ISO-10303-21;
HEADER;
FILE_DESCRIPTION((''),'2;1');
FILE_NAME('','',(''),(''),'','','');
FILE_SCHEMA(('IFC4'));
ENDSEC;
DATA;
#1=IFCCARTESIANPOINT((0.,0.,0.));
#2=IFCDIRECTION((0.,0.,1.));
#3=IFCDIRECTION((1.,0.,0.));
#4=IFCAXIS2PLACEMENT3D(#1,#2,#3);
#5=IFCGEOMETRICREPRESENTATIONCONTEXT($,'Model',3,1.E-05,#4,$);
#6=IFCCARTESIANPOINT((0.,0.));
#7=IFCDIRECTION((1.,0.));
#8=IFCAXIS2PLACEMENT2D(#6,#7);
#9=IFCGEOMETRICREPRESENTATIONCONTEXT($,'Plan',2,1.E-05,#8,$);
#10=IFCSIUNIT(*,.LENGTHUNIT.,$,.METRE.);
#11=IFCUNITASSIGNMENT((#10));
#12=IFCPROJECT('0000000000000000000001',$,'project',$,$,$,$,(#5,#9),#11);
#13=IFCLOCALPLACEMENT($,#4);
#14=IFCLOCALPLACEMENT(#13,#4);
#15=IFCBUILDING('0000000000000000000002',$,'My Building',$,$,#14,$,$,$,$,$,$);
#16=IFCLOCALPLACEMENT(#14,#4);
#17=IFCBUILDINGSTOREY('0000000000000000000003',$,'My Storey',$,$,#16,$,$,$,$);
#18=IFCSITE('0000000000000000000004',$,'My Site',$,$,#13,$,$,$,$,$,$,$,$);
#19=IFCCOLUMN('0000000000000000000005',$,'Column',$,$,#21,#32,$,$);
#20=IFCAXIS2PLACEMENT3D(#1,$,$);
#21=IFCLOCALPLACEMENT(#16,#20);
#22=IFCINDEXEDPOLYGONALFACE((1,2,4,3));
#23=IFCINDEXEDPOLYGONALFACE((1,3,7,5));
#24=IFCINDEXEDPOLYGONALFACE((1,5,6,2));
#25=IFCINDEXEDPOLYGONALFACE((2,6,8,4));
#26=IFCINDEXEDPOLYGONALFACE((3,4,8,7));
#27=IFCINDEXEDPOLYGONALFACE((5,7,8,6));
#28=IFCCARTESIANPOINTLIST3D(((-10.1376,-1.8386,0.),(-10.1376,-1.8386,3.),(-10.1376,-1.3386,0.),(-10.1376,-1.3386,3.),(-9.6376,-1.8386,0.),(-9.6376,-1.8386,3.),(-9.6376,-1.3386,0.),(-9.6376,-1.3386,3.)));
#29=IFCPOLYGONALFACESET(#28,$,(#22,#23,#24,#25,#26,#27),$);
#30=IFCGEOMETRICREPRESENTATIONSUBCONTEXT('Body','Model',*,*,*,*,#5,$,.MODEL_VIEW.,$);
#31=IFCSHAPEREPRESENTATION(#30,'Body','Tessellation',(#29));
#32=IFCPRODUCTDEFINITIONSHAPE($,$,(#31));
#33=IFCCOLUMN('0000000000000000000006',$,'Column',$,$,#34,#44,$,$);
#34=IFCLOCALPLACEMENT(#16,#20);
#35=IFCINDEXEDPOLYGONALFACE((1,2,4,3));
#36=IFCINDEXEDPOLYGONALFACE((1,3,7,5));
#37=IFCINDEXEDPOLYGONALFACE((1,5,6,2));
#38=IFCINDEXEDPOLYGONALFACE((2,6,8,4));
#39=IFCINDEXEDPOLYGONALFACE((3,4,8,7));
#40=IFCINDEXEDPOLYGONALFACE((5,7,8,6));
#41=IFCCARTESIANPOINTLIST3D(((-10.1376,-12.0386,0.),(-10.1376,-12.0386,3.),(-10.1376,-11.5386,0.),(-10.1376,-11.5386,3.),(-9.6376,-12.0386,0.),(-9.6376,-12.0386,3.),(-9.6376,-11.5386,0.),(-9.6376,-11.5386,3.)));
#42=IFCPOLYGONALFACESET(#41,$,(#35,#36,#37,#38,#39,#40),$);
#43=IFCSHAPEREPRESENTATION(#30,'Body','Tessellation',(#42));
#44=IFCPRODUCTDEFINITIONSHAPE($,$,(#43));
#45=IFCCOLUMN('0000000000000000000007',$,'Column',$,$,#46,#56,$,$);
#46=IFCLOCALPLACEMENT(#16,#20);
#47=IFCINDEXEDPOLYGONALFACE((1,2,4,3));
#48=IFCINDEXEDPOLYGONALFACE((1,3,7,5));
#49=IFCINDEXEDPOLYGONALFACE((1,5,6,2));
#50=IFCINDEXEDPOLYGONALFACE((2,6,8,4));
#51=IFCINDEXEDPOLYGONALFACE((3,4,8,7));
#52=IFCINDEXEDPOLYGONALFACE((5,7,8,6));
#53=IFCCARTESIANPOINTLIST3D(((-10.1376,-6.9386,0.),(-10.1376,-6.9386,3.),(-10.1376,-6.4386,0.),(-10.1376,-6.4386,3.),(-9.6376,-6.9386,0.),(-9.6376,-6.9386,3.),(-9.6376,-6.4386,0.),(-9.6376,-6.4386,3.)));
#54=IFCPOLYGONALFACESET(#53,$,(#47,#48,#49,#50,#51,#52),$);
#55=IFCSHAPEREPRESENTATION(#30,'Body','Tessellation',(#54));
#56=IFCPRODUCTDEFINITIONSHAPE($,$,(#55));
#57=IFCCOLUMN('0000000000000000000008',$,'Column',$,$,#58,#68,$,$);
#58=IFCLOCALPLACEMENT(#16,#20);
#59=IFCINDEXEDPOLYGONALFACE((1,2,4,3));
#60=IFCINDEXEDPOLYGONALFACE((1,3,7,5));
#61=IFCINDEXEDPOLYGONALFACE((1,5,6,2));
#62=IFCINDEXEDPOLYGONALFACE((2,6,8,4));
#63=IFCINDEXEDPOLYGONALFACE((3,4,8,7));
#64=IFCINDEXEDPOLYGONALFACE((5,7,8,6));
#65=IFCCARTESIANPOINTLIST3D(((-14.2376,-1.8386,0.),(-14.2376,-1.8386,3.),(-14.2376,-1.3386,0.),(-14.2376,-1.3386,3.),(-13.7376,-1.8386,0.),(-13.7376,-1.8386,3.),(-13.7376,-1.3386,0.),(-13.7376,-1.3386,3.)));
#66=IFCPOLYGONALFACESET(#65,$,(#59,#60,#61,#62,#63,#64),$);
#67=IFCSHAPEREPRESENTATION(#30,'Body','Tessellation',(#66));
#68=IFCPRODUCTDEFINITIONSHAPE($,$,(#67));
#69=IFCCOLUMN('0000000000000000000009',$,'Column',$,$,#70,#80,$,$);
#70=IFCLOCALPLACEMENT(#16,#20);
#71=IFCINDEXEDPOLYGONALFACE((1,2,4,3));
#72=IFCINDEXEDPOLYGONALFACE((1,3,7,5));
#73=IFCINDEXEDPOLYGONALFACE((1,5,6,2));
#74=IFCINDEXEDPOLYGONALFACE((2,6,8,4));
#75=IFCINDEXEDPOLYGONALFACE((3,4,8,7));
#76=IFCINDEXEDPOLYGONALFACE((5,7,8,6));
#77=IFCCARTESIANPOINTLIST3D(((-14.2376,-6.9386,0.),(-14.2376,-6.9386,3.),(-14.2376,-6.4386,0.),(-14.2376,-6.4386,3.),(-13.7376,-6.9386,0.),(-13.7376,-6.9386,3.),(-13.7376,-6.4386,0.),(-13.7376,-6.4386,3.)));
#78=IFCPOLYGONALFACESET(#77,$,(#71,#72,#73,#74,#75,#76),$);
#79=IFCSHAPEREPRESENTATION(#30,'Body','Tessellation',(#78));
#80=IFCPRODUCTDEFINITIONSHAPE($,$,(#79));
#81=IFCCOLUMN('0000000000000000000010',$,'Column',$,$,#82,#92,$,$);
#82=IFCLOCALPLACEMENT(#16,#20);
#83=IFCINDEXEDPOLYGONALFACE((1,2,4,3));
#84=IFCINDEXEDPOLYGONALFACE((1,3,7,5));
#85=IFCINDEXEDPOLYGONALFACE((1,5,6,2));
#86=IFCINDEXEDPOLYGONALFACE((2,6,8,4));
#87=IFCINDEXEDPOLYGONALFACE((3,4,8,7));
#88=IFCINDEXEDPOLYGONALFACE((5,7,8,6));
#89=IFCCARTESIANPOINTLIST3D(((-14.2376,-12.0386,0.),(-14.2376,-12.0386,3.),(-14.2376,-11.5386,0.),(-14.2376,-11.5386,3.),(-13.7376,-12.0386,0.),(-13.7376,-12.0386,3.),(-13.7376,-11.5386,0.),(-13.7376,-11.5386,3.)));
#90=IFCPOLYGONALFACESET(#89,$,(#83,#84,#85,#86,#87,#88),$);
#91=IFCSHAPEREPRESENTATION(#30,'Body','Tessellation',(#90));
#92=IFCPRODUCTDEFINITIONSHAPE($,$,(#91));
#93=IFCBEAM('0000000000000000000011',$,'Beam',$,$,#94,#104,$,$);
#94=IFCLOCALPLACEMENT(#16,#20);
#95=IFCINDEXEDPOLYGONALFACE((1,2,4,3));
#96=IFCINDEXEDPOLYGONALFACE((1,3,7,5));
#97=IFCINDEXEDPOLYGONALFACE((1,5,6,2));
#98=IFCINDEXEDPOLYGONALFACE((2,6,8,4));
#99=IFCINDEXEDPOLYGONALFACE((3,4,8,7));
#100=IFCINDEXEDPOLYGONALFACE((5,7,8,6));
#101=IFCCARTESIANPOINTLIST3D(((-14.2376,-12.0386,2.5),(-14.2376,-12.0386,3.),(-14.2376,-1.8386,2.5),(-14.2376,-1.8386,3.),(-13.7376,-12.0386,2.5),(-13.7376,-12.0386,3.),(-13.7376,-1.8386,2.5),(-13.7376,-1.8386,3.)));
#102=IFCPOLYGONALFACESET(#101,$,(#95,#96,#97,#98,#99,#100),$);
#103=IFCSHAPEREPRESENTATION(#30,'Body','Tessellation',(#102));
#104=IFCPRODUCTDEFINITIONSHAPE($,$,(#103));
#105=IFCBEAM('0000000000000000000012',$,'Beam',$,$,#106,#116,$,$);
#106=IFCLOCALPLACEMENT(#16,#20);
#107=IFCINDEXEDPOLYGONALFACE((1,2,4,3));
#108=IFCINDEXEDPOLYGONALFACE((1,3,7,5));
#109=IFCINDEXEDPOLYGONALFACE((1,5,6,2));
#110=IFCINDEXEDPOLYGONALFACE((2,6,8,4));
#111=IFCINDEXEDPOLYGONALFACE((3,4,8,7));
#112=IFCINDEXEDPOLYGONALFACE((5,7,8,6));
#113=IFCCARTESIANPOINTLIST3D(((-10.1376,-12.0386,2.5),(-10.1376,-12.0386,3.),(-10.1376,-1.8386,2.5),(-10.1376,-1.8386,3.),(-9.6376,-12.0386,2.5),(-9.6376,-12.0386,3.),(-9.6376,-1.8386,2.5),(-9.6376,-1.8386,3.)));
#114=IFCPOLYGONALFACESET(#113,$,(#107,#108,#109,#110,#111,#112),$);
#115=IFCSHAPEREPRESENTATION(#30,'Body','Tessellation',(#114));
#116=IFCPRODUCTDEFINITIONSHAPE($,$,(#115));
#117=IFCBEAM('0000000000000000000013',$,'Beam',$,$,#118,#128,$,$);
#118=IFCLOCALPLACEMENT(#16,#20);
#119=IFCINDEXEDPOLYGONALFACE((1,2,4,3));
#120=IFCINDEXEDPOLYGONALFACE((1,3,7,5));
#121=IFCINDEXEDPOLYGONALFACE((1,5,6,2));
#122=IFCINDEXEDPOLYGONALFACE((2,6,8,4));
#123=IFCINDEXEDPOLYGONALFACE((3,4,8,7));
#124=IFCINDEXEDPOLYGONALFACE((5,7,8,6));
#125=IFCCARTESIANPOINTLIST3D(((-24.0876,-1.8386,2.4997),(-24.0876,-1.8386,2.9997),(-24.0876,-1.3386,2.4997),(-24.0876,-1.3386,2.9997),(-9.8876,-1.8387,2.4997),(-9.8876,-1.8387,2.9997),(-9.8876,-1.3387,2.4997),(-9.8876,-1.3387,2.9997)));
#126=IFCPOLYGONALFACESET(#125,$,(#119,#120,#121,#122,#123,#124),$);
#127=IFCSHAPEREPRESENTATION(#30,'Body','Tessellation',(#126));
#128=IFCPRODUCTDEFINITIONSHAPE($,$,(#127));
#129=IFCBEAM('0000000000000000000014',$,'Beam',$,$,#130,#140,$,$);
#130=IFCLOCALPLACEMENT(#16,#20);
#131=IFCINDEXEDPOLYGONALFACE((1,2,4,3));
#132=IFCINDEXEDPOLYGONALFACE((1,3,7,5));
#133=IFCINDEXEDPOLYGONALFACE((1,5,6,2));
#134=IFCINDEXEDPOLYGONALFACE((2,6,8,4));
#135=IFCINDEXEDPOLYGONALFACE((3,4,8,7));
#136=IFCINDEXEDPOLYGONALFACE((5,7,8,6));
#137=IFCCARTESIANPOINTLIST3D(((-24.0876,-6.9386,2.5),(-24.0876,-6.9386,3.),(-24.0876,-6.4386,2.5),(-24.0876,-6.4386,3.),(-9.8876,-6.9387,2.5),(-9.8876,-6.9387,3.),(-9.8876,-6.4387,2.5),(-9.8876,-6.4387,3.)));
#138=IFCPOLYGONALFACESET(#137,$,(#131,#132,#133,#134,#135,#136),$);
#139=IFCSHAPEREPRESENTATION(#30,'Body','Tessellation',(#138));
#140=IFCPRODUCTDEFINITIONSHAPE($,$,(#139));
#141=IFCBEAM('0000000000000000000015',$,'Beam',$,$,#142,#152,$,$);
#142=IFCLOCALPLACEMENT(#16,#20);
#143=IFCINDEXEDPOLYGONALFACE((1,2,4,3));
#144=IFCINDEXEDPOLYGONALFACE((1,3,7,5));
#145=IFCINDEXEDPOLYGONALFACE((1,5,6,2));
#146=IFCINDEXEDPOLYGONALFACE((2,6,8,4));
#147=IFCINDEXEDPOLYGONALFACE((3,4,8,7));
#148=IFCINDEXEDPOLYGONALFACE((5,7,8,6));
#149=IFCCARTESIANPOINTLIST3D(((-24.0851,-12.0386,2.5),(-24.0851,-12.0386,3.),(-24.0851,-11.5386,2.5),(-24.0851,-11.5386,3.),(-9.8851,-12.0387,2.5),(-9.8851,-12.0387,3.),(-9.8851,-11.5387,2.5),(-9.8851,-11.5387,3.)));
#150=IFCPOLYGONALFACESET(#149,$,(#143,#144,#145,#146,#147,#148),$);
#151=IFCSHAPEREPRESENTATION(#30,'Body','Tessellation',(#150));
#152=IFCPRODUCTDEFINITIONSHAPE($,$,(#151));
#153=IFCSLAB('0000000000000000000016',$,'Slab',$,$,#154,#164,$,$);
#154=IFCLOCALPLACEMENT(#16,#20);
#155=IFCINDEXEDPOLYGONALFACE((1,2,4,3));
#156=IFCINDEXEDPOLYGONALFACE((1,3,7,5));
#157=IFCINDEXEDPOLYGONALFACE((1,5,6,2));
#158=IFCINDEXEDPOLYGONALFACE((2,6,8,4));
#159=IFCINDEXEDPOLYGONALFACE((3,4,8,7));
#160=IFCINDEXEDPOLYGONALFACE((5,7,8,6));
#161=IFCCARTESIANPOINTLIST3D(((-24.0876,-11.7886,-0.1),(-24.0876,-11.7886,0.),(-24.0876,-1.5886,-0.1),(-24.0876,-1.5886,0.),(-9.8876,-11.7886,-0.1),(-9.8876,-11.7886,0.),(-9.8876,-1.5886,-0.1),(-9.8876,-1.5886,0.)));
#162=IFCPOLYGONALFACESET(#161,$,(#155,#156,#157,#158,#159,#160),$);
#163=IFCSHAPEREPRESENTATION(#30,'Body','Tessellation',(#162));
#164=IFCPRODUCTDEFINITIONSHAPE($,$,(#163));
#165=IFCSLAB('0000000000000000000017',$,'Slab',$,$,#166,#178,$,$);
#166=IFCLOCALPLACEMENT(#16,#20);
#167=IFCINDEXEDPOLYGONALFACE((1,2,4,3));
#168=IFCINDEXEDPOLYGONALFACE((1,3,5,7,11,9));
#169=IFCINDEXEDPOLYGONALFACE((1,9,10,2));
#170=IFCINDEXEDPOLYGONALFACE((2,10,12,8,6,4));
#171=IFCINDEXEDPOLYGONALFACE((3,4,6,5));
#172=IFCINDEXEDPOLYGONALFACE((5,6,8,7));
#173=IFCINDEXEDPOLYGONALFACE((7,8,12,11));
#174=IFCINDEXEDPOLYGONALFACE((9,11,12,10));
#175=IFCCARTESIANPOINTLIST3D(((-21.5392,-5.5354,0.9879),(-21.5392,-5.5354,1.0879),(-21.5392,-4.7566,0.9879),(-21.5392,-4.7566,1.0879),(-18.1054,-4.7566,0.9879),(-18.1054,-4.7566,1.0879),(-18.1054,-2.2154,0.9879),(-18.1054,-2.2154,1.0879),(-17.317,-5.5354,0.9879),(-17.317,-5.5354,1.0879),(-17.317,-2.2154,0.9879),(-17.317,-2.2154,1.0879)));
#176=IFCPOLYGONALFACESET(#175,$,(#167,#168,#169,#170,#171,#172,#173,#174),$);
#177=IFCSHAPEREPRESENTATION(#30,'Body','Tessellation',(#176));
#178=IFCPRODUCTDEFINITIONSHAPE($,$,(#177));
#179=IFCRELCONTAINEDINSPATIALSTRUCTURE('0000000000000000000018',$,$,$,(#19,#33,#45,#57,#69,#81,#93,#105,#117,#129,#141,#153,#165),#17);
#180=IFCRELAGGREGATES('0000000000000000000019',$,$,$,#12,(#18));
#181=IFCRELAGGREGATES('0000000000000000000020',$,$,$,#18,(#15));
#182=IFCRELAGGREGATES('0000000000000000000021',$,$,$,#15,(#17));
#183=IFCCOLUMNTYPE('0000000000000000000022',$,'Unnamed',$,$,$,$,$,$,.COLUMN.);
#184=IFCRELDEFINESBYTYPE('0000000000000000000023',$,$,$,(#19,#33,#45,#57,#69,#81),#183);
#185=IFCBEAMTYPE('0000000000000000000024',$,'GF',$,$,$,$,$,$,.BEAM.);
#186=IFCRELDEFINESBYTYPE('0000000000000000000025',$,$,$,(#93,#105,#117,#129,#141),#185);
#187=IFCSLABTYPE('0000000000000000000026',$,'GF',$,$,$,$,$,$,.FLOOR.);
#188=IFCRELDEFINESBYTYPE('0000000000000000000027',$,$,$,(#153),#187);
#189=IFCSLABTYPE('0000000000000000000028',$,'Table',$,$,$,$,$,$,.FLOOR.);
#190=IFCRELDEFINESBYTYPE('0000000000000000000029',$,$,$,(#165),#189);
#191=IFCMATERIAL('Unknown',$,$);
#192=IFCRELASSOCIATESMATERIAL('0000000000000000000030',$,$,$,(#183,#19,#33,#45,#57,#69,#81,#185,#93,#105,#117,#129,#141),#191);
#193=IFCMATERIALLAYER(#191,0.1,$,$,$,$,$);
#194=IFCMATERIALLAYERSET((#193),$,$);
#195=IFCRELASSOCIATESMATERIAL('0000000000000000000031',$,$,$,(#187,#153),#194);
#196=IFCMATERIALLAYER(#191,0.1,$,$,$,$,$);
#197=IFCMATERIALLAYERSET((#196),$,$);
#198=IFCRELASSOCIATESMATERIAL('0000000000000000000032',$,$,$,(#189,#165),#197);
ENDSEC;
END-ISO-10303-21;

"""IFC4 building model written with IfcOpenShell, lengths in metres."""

from ifc_helpers import new_model, si_unit, frame, origin_with_axes, origin_2d_with_axis, place, context, subcontext, project, spatial, indexed_curve, rectangle, outline, extrude, material, layer, layer_set, layer_usage, material_profile, profile_set, profile_usage, type_object, element, save


model = new_model("IFC4")

# Units and contexts
model_context = context("Model", 3, precision=1e-05, world=origin_with_axes())
plan_context = context("Plan", 2, precision=1e-05, world=origin_2d_with_axis())
body_context_1 = subcontext(model_context, "Body", "Model", "MODEL_VIEW")
ifc_project = project(units=[si_unit("LENGTHUNIT", "METRE")], contexts=[model_context, plan_context])

# Site, building, storey
site_placement = place(None, origin_with_axes())
site = spatial("IfcSite", under=ifc_project, at=site_placement, Name="My Site")
building_placement = place(site_placement, origin_with_axes())
building = spatial("IfcBuilding", under=site, at=building_placement, Name="My Building")
storey_placement = place(building_placement, origin_with_axes())
storey = spatial("IfcBuildingStorey", under=building, at=storey_placement, Name="My Storey")

# Columns
ifc_material = material(Name="Unknown")
ifc_material_profile_1 = material_profile(ifc_material, rectangle(XDim=0.5, YDim=0.5))
ifc_profile_set_1 = profile_set([ifc_material_profile_1])
ifc_profile_usage_1 = profile_usage(ifc_profile_set_1, cardinal=5)
column_type = type_object("IfcColumnType", Name="Unnamed", PredefinedType="COLUMN", material=ifc_profile_set_1)
column_1_placement = place(storey_placement, frame((-9.8876, -1.5886, 0.0), z_axis=(0.0, 0.0, 1.0), x_axis=(0.0, -1.0, 0.0)))
element("IfcColumn", 1, at=column_1_placement, inside=storey, type_object=column_type, material=ifc_profile_usage_1, Name="Column", context=body_context_1, shape_type="SweptSolid", body=[
    extrude(rectangle(XDim=0.5, YDim=0.5), origin_with_axes(), (0.0, 0.0, 1.0), 3.0),
])
ifc_profile_usage_2 = profile_usage(ifc_profile_set_1, cardinal=5)
column_2_placement = place(storey_placement, frame((-9.8876, -11.7886, 0.0), z_axis=(0.0, 0.0, 1.0), x_axis=(0.0, -1.0, 0.0)))
element("IfcColumn", 2, at=column_2_placement, inside=storey, type_object=column_type, material=ifc_profile_usage_2, Name="Column", context=body_context_1, shape_type="SweptSolid", body=[
    extrude(rectangle(XDim=0.5, YDim=0.5), origin_with_axes(), (0.0, 0.0, 1.0), 3.0),
])
ifc_profile_usage_3 = profile_usage(ifc_profile_set_1, cardinal=5)
column_3_placement = place(storey_placement, frame((-9.8876, -6.6886, 0.0), z_axis=(0.0, 0.0, 1.0), x_axis=(0.0, -1.0, 0.0)))
element("IfcColumn", 3, at=column_3_placement, inside=storey, type_object=column_type, material=ifc_profile_usage_3, Name="Column", context=body_context_1, shape_type="SweptSolid", body=[
    extrude(rectangle(XDim=0.5, YDim=0.5), origin_with_axes(), (0.0, 0.0, 1.0), 3.0),
])
ifc_profile_usage_4 = profile_usage(ifc_profile_set_1, cardinal=5)
column_4_placement = place(storey_placement, frame((-13.9876, -1.5886, 0.0), z_axis=(0.0, 0.0, 1.0), x_axis=(0.0, -1.0, 0.0)))
element("IfcColumn", 4, at=column_4_placement, inside=storey, type_object=column_type, material=ifc_profile_usage_4, Name="Column", context=body_context_1, shape_type="SweptSolid", body=[
    extrude(rectangle(XDim=0.5, YDim=0.5), origin_with_axes(), (0.0, 0.0, 1.0), 3.0),
])
ifc_profile_usage_5 = profile_usage(ifc_profile_set_1, cardinal=5)
column_5_placement = place(storey_placement, frame((-13.9876, -6.6886, 0.0), z_axis=(0.0, 0.0, 1.0), x_axis=(0.0, -1.0, 0.0)))
element("IfcColumn", 5, at=column_5_placement, inside=storey, type_object=column_type, material=ifc_profile_usage_5, Name="Column", context=body_context_1, shape_type="SweptSolid", body=[
    extrude(rectangle(XDim=0.5, YDim=0.5), origin_with_axes(), (0.0, 0.0, 1.0), 3.0),
])
ifc_profile_usage_6 = profile_usage(ifc_profile_set_1, cardinal=5)
column_6_placement = place(storey_placement, frame((-13.9876, -11.7886, 0.0), z_axis=(0.0, 0.0, 1.0), x_axis=(0.0, -1.0, 0.0)))
element("IfcColumn", 6, at=column_6_placement, inside=storey, type_object=column_type, material=ifc_profile_usage_6, Name="Column", context=body_context_1, shape_type="SweptSolid", body=[
    extrude(rectangle(XDim=0.5, YDim=0.5), origin_with_axes(), (0.0, 0.0, 1.0), 3.0),
])

# Beams
ifc_material_profile_2 = material_profile(ifc_material, rectangle(XDim=0.5, YDim=0.5))
ifc_profile_set_2 = profile_set([ifc_material_profile_2])
ifc_profile_usage_7 = profile_usage(ifc_profile_set_2, cardinal=1)
beam_type = type_object("IfcBeamType", Name="GF", PredefinedType="BEAM", material=ifc_profile_set_2)
beam_1_placement = place(storey_placement, frame((-13.7376, -1.8386, 2.5), z_axis=(-0.000001, -1.0, 0.0), x_axis=(1.0, -0.000001, 0.0)))
element("IfcBeam", 7, at=beam_1_placement, inside=storey, type_object=beam_type, material=ifc_profile_usage_7, Name="Beam", context=body_context_1, shape_type="SweptSolid", body=[
    extrude(rectangle(XDim=0.5, YDim=0.5), frame((-0.25, 0.25, 0.0), z_axis=(0.0, 0.0, 1.0), x_axis=(1.0, 0.0, 0.0)), (0.0, 0.0, 1.0), 10.2),
])
ifc_profile_usage_8 = profile_usage(ifc_profile_set_2, cardinal=1)
beam_2_placement = place(storey_placement, frame((-9.6376, -1.8386, 2.5), z_axis=(-0.000001, -1.0, 0.0), x_axis=(1.0, -0.000001, 0.0)))
element("IfcBeam", 8, at=beam_2_placement, inside=storey, type_object=beam_type, material=ifc_profile_usage_8, Name="Beam", context=body_context_1, shape_type="SweptSolid", body=[
    extrude(rectangle(XDim=0.5, YDim=0.5), frame((-0.25, 0.25, 0.0), z_axis=(0.0, 0.0, 1.0), x_axis=(1.0, 0.0, 0.0)), (0.0, 0.0, 1.0), 10.2),
])
ifc_profile_usage_9 = profile_usage(ifc_profile_set_2, cardinal=1)
beam_3_placement = place(storey_placement, frame((-9.8876, -1.8387, 2.4997), z_axis=(-1.0, 0.0, 0.0), x_axis=(0.0, -1.0, 0.0)))
element("IfcBeam", 9, at=beam_3_placement, inside=storey, type_object=beam_type, material=ifc_profile_usage_9, Name="Beam", context=body_context_1, shape_type="SweptSolid", body=[
    extrude(rectangle(XDim=0.5, YDim=0.5), frame((-0.25, 0.25, 0.0), z_axis=(0.0, 0.0, 1.0), x_axis=(1.0, 0.0, 0.0)), (0.0, 0.0, 1.0), 14.2),
])
ifc_profile_usage_10 = profile_usage(ifc_profile_set_2, cardinal=1)
beam_4_placement = place(storey_placement, frame((-9.8876, -6.9387, 2.5), z_axis=(-1.0, 0.0, 0.0), x_axis=(0.0, -1.0, 0.0)))
element("IfcBeam", 10, at=beam_4_placement, inside=storey, type_object=beam_type, material=ifc_profile_usage_10, Name="Beam", context=body_context_1, shape_type="SweptSolid", body=[
    extrude(rectangle(XDim=0.5, YDim=0.5), frame((-0.25, 0.25, 0.0), z_axis=(0.0, 0.0, 1.0), x_axis=(1.0, 0.0, 0.0)), (0.0, 0.0, 1.0), 14.2),
])
ifc_profile_usage_11 = profile_usage(ifc_profile_set_2, cardinal=1)
beam_5_placement = place(storey_placement, frame((-9.8851, -12.0387, 2.5), z_axis=(-1.0, 0.0, 0.0), x_axis=(0.0, -1.0, 0.0)))
element("IfcBeam", 11, at=beam_5_placement, inside=storey, type_object=beam_type, material=ifc_profile_usage_11, Name="Beam", context=body_context_1, shape_type="SweptSolid", body=[
    extrude(rectangle(XDim=0.5, YDim=0.5), frame((-0.25, 0.25, 0.0), z_axis=(0.0, 0.0, 1.0), x_axis=(1.0, 0.0, 0.0)), (0.0, 0.0, 1.0), 14.2),
])

# Slabs
ifc_layer_1 = layer(ifc_material, 0.1)
ifc_layer_set_1 = layer_set([ifc_layer_1])
ifc_layer_usage_1 = layer_usage(ifc_layer_set_1, "AXIS3", "POSITIVE", -0.1)
slab_type_1 = type_object("IfcSlabType", Name="GF", PredefinedType="FLOOR", material=ifc_layer_set_1)
slab_1_placement = place(storey_placement, frame((-9.8876, -1.5886, 0.0), z_axis=(0.0, 0.0, 1.0), x_axis=(0.0, -1.0, 0.0)))
element("IfcSlab", 12, at=slab_1_placement, inside=storey, type_object=slab_type_1, material=ifc_layer_usage_1, Name="Slab", context=body_context_1, shape_type="SweptSolid", body=[
    extrude(outline(indexed_curve([(0.0, 0.0), (10.2, 0.0), (10.2, -14.2), (0.0, -14.2), (0.0, 0.0)])), frame((0.0, 0.0, -0.1), z_axis=(0.0, 0.0, 1.0), x_axis=(1.0, 0.0, 0.0)), (0.0, 0.0, 1.0), 0.1),
])
ifc_layer_2 = layer(ifc_material, 0.1)
ifc_layer_set_2 = layer_set([ifc_layer_2])
ifc_layer_usage_2 = layer_usage(ifc_layer_set_2, "AXIS3", "POSITIVE", -0.1)
slab_type_2 = type_object("IfcSlabType", Name="Table", PredefinedType="FLOOR", material=ifc_layer_set_2)
slab_2_placement = place(storey_placement, frame((-18.1054, -2.2154, 1.0879), z_axis=(0.0, 0.0, 1.0), x_axis=(0.0, -1.0, 0.0)))
element("IfcSlab", 13, at=slab_2_placement, inside=storey, type_object=slab_type_2, material=ifc_layer_usage_2, Name="Slab", context=body_context_1, shape_type="SweptSolid", body=[
    extrude(outline(indexed_curve([(0.0, 0.0), (0.0, 0.7885), (3.3201, 0.7885), (3.3201, -3.4337), (2.5413, -3.4337), (2.5413, 0.0), (0.0, 0.0)])), frame((0.0, 0.0, -0.1), z_axis=(0.0, 0.0, 1.0), x_axis=(1.0, 0.0, 0.0)), (0.0, 0.0, 1.0), 0.1),
])

save(model, "model.ifc")
